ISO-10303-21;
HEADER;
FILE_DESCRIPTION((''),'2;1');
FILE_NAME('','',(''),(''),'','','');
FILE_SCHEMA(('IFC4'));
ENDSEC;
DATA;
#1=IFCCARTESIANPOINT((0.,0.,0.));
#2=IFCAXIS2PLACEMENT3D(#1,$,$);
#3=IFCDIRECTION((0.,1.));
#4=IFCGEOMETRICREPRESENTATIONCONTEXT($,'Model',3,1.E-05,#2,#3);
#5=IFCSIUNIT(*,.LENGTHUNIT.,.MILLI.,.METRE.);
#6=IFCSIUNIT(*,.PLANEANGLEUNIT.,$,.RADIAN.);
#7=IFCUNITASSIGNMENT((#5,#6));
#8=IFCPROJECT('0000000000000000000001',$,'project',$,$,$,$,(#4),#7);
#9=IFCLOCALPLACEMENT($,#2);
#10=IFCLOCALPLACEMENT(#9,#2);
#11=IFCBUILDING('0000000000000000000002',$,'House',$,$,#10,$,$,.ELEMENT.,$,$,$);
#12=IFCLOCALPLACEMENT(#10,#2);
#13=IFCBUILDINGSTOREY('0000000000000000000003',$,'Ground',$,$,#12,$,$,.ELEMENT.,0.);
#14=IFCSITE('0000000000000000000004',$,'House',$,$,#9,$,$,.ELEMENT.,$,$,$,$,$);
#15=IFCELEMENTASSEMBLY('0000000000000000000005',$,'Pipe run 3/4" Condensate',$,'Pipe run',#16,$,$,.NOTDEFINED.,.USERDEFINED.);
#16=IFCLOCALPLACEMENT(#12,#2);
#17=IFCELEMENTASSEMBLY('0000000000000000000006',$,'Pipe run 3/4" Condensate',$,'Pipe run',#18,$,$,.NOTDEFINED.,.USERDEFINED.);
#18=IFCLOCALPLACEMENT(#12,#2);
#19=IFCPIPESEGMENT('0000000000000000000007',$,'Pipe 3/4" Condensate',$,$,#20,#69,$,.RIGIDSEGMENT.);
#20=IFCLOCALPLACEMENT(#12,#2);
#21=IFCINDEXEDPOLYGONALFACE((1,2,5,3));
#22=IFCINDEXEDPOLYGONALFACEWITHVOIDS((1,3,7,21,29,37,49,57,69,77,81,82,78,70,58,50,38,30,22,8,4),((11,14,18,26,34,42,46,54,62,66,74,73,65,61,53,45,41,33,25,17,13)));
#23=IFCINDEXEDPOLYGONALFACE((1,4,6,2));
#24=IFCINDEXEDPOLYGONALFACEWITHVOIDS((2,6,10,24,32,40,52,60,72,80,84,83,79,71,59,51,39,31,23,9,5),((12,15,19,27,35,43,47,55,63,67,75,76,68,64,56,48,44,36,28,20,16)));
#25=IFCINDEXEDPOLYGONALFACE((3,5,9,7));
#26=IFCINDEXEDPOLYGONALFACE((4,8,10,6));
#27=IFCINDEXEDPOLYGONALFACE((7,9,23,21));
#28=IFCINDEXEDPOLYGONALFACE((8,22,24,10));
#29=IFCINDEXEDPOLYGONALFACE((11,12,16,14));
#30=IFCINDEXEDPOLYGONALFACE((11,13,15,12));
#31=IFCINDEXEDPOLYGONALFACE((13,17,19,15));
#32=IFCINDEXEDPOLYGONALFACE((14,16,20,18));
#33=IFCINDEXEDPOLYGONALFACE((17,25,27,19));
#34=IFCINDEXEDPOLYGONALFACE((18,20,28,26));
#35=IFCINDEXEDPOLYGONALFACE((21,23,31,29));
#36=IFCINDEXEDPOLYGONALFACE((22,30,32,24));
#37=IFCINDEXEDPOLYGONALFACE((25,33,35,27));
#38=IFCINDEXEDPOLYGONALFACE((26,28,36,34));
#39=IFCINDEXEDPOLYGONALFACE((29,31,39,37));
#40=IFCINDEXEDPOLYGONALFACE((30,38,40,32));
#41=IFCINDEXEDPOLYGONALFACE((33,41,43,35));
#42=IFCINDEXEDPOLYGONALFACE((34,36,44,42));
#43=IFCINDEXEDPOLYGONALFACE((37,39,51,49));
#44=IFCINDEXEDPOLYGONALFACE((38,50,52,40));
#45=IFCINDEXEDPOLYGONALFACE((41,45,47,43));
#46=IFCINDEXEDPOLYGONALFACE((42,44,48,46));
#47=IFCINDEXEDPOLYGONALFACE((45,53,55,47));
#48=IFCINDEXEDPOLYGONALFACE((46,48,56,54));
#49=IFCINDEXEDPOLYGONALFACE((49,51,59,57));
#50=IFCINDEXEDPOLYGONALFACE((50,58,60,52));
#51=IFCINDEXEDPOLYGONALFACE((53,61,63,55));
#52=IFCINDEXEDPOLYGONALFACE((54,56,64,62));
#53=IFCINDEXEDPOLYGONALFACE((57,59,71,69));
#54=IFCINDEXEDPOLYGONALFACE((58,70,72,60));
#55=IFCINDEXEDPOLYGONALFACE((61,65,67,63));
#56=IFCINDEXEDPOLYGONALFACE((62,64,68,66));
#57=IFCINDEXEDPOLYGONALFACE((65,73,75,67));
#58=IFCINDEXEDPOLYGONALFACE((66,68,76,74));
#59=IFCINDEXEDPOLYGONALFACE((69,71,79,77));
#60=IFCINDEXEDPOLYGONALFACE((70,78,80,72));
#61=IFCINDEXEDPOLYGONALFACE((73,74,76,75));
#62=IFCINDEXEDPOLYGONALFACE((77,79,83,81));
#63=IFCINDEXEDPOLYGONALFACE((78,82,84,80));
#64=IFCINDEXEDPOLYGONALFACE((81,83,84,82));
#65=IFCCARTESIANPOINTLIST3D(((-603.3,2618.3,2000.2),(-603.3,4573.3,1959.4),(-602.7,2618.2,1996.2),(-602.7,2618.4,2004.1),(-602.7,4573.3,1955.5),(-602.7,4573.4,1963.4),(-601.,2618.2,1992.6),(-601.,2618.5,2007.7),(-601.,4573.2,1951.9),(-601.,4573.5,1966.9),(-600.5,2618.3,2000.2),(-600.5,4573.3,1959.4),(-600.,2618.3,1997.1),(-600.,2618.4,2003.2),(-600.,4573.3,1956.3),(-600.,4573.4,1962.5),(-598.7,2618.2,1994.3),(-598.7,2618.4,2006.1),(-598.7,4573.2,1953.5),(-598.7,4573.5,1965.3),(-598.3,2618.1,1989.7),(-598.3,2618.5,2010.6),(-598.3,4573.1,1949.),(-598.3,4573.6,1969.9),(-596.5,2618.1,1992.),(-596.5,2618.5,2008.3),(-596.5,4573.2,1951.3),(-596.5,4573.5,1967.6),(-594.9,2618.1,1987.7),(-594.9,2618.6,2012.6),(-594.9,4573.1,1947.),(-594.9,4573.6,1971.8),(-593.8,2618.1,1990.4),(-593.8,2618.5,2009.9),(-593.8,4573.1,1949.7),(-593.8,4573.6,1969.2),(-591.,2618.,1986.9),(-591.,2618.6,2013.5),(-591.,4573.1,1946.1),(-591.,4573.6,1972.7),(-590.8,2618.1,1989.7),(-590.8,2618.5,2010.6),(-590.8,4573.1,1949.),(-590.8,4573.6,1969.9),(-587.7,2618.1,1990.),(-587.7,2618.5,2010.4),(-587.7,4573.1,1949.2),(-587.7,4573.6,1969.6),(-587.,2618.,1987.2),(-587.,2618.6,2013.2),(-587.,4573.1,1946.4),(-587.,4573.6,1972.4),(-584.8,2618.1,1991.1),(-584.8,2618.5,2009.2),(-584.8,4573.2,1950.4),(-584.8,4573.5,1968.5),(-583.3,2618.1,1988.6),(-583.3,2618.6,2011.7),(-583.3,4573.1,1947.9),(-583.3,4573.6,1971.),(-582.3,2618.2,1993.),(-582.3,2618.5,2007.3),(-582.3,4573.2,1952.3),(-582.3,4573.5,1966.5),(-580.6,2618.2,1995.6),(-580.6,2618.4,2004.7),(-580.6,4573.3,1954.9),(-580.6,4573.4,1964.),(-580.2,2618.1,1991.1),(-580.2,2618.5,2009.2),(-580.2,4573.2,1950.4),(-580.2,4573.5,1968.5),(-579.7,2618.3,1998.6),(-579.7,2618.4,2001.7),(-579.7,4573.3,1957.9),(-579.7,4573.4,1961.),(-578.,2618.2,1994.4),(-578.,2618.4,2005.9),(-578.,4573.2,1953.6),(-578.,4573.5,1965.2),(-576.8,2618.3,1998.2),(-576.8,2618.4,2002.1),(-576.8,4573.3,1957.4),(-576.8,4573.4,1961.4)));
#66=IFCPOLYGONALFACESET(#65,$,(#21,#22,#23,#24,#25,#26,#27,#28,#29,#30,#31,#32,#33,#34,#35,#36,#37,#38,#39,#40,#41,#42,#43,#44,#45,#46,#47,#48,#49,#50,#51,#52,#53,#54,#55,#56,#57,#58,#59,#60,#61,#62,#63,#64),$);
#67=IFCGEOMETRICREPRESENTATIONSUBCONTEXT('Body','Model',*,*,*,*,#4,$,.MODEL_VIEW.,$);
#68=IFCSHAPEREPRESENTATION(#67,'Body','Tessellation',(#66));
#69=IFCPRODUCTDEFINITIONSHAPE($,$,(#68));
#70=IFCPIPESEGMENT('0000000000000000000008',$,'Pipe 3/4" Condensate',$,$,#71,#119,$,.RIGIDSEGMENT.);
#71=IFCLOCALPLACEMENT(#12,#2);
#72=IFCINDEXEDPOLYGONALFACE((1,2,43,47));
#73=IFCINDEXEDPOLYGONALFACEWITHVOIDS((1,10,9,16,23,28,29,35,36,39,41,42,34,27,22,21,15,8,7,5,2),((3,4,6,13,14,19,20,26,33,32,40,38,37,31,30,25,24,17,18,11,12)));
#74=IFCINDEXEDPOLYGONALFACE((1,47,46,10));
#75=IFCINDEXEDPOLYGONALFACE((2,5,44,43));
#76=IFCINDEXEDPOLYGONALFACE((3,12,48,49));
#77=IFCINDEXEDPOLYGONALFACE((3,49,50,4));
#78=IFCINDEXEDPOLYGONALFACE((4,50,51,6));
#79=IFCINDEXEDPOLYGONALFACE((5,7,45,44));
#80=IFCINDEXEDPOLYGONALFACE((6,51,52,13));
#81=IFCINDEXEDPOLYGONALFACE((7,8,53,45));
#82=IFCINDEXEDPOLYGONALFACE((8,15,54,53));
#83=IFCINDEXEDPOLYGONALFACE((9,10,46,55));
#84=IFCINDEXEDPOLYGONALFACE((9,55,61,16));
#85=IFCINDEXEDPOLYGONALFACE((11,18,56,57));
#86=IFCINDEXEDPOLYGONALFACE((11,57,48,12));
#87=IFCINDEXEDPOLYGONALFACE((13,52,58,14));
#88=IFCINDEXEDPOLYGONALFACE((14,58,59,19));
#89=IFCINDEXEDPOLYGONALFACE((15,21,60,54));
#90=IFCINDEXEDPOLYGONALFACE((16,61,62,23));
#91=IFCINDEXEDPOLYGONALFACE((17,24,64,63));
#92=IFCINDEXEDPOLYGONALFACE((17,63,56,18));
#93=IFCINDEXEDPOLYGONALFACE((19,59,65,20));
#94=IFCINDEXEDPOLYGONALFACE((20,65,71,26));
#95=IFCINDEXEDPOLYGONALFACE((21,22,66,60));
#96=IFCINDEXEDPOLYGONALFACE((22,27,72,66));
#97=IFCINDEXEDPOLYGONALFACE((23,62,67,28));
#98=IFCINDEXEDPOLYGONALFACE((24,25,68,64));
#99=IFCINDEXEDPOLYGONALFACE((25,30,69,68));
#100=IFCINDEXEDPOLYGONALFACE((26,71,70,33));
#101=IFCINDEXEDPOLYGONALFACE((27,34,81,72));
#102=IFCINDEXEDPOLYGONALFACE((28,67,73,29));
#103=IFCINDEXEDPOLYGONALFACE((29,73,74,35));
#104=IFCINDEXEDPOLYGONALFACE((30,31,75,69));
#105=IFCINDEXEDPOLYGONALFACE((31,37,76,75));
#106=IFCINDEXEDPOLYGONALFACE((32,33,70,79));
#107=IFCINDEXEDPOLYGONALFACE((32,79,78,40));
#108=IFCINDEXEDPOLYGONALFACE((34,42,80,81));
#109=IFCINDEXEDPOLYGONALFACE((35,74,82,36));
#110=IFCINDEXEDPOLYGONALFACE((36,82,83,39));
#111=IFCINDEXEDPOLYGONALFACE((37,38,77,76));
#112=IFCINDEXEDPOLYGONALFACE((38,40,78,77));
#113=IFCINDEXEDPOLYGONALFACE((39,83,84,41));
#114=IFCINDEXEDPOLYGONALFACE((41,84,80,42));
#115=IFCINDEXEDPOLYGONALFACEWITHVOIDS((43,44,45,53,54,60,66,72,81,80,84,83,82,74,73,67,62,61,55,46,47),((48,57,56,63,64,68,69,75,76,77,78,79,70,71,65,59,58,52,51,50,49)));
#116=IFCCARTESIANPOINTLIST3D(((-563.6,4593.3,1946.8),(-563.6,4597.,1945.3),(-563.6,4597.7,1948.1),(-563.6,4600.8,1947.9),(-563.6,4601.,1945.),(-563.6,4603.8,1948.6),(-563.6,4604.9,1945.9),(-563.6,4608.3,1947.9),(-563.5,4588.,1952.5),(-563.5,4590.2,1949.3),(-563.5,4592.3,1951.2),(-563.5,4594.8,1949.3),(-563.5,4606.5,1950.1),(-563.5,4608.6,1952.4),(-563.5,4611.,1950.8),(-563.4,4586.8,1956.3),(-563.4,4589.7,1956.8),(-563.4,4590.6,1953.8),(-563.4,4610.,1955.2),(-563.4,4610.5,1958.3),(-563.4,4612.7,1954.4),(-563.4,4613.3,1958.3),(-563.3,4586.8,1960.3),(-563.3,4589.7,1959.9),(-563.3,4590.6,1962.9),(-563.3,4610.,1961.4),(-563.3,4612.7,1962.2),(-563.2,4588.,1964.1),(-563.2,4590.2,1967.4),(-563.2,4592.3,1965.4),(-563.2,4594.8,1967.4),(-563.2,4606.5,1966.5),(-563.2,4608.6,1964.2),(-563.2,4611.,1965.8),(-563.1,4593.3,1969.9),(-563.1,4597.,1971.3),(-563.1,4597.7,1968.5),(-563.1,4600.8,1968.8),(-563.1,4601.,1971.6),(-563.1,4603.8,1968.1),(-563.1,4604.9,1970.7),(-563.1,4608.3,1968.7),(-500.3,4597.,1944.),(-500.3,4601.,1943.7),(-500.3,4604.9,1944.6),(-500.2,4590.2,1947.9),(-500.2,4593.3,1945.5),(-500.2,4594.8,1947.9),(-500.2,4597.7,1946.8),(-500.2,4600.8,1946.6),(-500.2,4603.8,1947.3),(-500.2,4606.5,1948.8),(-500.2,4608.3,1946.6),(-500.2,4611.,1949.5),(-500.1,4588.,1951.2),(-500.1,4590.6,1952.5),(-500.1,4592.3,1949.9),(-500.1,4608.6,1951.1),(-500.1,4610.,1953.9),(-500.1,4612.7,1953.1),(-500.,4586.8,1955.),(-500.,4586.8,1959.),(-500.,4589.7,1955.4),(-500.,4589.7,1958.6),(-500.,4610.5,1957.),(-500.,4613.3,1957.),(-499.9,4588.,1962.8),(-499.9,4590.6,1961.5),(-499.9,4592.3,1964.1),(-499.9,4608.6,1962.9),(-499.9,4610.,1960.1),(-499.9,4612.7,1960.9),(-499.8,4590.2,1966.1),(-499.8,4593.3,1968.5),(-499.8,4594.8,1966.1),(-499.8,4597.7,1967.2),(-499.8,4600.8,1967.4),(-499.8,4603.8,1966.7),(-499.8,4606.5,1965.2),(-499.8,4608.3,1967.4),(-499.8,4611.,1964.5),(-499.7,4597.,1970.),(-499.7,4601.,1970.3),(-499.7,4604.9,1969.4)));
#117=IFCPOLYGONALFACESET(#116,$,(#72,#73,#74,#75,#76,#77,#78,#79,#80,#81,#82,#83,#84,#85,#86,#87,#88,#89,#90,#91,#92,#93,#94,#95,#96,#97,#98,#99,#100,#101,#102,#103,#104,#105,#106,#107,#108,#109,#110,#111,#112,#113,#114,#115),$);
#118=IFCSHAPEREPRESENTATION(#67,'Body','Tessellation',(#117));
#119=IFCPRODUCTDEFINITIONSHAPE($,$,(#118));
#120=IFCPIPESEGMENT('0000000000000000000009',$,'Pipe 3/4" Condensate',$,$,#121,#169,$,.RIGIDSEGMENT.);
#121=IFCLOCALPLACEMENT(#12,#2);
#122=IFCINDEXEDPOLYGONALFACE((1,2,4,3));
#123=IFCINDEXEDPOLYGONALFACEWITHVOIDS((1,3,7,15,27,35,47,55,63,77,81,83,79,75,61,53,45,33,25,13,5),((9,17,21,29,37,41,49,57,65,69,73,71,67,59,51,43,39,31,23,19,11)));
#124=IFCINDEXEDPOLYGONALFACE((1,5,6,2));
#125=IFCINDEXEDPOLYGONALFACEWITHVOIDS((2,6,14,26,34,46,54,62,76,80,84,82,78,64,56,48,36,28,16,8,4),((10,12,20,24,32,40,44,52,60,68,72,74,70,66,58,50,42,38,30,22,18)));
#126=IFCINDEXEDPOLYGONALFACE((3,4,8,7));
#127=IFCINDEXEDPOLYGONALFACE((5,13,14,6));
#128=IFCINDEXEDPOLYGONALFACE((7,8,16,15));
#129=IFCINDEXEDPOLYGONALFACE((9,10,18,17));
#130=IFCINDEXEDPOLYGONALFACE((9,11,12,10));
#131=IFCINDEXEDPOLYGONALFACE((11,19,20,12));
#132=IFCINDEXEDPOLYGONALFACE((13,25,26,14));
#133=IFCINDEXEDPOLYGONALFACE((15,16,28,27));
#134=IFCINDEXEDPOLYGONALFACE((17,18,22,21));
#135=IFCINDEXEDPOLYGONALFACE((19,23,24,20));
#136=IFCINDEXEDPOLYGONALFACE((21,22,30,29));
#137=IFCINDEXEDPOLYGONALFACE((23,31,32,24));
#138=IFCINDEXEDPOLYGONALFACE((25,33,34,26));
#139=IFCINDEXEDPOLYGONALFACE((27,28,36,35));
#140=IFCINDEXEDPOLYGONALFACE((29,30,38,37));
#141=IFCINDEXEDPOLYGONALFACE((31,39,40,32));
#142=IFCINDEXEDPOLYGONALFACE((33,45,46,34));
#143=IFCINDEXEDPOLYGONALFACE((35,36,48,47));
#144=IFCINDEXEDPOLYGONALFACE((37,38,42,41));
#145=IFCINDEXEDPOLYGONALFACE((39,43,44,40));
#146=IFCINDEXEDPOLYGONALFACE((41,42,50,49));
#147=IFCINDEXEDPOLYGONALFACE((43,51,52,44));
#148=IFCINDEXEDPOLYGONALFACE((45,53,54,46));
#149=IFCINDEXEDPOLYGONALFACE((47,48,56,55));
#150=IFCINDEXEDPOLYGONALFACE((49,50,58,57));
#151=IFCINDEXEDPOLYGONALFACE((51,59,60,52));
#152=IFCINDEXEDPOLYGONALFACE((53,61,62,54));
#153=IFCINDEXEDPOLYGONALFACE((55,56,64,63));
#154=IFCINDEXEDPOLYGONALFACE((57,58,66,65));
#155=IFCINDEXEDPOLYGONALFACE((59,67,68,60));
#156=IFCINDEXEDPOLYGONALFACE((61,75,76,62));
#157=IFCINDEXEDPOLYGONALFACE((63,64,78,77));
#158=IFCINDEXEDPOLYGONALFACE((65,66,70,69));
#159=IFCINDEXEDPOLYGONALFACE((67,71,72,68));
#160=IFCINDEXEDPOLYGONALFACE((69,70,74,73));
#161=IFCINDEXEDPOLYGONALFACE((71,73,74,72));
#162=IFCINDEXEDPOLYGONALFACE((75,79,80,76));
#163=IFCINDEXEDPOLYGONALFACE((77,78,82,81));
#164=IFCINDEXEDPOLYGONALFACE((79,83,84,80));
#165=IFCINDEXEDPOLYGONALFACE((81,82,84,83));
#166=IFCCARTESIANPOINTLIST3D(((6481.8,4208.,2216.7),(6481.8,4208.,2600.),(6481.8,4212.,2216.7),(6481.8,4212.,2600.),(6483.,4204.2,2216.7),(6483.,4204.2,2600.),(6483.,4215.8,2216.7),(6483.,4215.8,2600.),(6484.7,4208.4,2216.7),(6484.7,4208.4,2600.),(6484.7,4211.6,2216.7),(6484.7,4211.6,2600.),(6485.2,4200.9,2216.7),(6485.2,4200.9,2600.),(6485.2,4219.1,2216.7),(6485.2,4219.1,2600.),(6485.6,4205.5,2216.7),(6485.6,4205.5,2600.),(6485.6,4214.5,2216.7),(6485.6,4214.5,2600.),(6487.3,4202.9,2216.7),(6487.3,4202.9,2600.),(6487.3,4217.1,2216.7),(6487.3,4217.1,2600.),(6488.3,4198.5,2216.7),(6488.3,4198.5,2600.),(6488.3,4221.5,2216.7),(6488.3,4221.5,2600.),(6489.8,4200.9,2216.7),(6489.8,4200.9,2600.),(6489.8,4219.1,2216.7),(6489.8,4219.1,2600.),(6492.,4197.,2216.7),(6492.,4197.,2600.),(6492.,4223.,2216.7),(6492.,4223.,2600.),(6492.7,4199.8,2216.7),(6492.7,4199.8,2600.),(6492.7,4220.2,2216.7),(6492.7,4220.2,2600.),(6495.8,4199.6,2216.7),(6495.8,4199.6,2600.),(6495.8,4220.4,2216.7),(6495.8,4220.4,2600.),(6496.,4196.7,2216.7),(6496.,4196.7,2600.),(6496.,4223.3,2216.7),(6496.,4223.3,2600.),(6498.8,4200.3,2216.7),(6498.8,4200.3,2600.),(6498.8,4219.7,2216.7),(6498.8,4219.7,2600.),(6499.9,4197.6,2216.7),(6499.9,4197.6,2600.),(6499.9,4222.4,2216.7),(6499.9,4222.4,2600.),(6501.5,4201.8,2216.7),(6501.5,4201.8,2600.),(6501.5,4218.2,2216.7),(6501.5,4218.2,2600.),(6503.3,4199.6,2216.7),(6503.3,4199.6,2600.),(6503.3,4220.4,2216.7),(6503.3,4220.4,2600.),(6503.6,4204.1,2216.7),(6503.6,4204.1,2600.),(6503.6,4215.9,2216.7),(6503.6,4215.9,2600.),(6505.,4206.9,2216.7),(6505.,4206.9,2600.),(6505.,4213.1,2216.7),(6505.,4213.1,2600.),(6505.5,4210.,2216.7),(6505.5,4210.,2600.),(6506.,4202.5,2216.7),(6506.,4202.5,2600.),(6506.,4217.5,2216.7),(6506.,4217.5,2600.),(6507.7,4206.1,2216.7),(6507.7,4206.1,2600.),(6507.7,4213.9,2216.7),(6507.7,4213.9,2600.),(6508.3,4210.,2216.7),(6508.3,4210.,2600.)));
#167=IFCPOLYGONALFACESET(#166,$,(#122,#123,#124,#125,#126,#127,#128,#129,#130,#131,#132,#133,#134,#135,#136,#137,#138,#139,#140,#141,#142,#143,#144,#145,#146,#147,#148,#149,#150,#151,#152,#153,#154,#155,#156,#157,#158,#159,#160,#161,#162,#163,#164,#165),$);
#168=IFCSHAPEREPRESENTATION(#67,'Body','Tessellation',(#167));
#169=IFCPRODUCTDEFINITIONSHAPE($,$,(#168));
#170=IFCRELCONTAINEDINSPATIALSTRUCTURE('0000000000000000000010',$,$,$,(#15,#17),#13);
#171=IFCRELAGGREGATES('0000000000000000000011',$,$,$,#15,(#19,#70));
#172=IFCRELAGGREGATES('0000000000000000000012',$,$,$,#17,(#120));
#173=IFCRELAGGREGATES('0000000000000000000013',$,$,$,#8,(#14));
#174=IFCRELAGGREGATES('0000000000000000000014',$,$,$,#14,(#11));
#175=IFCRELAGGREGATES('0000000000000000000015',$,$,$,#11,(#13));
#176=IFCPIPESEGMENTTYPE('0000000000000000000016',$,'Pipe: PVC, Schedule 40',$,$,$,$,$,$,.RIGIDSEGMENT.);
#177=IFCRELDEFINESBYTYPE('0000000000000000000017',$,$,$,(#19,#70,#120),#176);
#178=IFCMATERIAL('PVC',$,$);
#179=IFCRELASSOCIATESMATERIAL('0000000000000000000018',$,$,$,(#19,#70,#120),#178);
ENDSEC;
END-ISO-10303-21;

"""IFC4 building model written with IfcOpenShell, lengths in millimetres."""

from ifc_helpers import new_model, si_unit, direction, frame, origin, origin_with_axes, origin_2d, place, context, subcontext, project, spatial, hollow_circle, extrude, material, type_object, element, aggregate, save


model = new_model("IFC4")

# Units and contexts
model_context = context("Model", 3, precision=1e-05, world=origin(), true_north=direction((0.0, 1.0)))
body_context = subcontext(model_context, "Body", "Model", "MODEL_VIEW")
ifc_project = project(units=[si_unit("LENGTHUNIT", "METRE", prefix="MILLI"), si_unit("PLANEANGLEUNIT", "RADIAN")], contexts=[model_context])

# Site, building, storey
site_placement = place(None, origin())
site = spatial("IfcSite", under=ifc_project, at=site_placement, Name="House", CompositionType="ELEMENT")
building_placement = place(site_placement, origin())
building = spatial("IfcBuilding", under=site, at=building_placement, Name="House", CompositionType="ELEMENT")
storey_placement = place(building_placement, origin())
storey = spatial("IfcBuildingStorey", under=building, at=storey_placement, Name="Ground", CompositionType="ELEMENT", Elevation=0.0)

# Element assemblies
ifc_material_1 = material(Name="PVC")
assembly_1_placement = place(storey_placement, origin_with_axes())
assembly_1 = element("IfcElementAssembly", 1, at=assembly_1_placement, inside=storey, Name="Pipe run 3/4\" Condensate", ObjectType="Pipe run", AssemblyPlace="NOTDEFINED", PredefinedType="USERDEFINED")
assembly_2_placement = place(storey_placement, origin_with_axes())
assembly_2 = element("IfcElementAssembly", 2, at=assembly_2_placement, inside=storey, Name="Pipe run 3/4\" Condensate", ObjectType="Pipe run", AssemblyPlace="NOTDEFINED", PredefinedType="USERDEFINED")

# Pipe segments
pipe_segment_type_1 = type_object("IfcPipeSegmentType", Name="Pipe: PVC, Schedule 40", PredefinedType="RIGIDSEGMENT")
pipe_segment_1_placement = place(storey_placement, origin_with_axes())
pipe_segment_1 = element("IfcPipeSegment", 3, at=pipe_segment_1_placement, type_object=pipe_segment_type_1, material=ifc_material_1, Name="Pipe 3/4\" Condensate", PredefinedType="RIGIDSEGMENT", context=body_context, shape_type="SweptSolid", body=[
    extrude(hollow_circle(Radius=13.3, WallThickness=2.9, at=origin_2d()), frame((-590.0, 2618.3, 2000.2), z_axis=(0.0, 0.999783, -0.020829), x_axis=(-1.0, 0.0, 0.0)), (0.0, 0.0, 1.0), 1955.5),
])
pipe_segment_2_placement = place(storey_placement, origin_with_axes())
pipe_segment_2 = element("IfcPipeSegment", 4, at=pipe_segment_2_placement, type_object=pipe_segment_type_1, material=ifc_material_1, Name="Pipe 3/4\" Condensate", PredefinedType="RIGIDSEGMENT", context=body_context, shape_type="SweptSolid", body=[
    extrude(hollow_circle(Radius=13.3, WallThickness=2.9, at=origin_2d()), frame((-563.4, 4600.0, 1958.3), z_axis=(0.999783, 0.0, -0.020829), x_axis=(0.0, 1.0, 0.0)), (0.0, 0.0, 1.0), 63.4),
])
aggregate(assembly_1, [pipe_segment_1, pipe_segment_2])
pipe_segment_3_placement = place(storey_placement, origin_with_axes())
pipe_segment_3 = element("IfcPipeSegment", 5, at=pipe_segment_3_placement, type_object=pipe_segment_type_1, material=ifc_material_1, Name="Pipe 3/4\" Condensate", PredefinedType="RIGIDSEGMENT", context=body_context, shape_type="SweptSolid", body=[
    extrude(hollow_circle(Radius=13.3, WallThickness=2.9, at=origin_2d()), frame((6495.0, 4210.0, 2600.0), z_axis=(0.0, 0.0, -1.0), x_axis=(1.0, 0.0, 0.0)), (0.0, 0.0, 1.0), 383.3),
])
aggregate(assembly_2, [pipe_segment_3])

save(model, "model.ifc")
